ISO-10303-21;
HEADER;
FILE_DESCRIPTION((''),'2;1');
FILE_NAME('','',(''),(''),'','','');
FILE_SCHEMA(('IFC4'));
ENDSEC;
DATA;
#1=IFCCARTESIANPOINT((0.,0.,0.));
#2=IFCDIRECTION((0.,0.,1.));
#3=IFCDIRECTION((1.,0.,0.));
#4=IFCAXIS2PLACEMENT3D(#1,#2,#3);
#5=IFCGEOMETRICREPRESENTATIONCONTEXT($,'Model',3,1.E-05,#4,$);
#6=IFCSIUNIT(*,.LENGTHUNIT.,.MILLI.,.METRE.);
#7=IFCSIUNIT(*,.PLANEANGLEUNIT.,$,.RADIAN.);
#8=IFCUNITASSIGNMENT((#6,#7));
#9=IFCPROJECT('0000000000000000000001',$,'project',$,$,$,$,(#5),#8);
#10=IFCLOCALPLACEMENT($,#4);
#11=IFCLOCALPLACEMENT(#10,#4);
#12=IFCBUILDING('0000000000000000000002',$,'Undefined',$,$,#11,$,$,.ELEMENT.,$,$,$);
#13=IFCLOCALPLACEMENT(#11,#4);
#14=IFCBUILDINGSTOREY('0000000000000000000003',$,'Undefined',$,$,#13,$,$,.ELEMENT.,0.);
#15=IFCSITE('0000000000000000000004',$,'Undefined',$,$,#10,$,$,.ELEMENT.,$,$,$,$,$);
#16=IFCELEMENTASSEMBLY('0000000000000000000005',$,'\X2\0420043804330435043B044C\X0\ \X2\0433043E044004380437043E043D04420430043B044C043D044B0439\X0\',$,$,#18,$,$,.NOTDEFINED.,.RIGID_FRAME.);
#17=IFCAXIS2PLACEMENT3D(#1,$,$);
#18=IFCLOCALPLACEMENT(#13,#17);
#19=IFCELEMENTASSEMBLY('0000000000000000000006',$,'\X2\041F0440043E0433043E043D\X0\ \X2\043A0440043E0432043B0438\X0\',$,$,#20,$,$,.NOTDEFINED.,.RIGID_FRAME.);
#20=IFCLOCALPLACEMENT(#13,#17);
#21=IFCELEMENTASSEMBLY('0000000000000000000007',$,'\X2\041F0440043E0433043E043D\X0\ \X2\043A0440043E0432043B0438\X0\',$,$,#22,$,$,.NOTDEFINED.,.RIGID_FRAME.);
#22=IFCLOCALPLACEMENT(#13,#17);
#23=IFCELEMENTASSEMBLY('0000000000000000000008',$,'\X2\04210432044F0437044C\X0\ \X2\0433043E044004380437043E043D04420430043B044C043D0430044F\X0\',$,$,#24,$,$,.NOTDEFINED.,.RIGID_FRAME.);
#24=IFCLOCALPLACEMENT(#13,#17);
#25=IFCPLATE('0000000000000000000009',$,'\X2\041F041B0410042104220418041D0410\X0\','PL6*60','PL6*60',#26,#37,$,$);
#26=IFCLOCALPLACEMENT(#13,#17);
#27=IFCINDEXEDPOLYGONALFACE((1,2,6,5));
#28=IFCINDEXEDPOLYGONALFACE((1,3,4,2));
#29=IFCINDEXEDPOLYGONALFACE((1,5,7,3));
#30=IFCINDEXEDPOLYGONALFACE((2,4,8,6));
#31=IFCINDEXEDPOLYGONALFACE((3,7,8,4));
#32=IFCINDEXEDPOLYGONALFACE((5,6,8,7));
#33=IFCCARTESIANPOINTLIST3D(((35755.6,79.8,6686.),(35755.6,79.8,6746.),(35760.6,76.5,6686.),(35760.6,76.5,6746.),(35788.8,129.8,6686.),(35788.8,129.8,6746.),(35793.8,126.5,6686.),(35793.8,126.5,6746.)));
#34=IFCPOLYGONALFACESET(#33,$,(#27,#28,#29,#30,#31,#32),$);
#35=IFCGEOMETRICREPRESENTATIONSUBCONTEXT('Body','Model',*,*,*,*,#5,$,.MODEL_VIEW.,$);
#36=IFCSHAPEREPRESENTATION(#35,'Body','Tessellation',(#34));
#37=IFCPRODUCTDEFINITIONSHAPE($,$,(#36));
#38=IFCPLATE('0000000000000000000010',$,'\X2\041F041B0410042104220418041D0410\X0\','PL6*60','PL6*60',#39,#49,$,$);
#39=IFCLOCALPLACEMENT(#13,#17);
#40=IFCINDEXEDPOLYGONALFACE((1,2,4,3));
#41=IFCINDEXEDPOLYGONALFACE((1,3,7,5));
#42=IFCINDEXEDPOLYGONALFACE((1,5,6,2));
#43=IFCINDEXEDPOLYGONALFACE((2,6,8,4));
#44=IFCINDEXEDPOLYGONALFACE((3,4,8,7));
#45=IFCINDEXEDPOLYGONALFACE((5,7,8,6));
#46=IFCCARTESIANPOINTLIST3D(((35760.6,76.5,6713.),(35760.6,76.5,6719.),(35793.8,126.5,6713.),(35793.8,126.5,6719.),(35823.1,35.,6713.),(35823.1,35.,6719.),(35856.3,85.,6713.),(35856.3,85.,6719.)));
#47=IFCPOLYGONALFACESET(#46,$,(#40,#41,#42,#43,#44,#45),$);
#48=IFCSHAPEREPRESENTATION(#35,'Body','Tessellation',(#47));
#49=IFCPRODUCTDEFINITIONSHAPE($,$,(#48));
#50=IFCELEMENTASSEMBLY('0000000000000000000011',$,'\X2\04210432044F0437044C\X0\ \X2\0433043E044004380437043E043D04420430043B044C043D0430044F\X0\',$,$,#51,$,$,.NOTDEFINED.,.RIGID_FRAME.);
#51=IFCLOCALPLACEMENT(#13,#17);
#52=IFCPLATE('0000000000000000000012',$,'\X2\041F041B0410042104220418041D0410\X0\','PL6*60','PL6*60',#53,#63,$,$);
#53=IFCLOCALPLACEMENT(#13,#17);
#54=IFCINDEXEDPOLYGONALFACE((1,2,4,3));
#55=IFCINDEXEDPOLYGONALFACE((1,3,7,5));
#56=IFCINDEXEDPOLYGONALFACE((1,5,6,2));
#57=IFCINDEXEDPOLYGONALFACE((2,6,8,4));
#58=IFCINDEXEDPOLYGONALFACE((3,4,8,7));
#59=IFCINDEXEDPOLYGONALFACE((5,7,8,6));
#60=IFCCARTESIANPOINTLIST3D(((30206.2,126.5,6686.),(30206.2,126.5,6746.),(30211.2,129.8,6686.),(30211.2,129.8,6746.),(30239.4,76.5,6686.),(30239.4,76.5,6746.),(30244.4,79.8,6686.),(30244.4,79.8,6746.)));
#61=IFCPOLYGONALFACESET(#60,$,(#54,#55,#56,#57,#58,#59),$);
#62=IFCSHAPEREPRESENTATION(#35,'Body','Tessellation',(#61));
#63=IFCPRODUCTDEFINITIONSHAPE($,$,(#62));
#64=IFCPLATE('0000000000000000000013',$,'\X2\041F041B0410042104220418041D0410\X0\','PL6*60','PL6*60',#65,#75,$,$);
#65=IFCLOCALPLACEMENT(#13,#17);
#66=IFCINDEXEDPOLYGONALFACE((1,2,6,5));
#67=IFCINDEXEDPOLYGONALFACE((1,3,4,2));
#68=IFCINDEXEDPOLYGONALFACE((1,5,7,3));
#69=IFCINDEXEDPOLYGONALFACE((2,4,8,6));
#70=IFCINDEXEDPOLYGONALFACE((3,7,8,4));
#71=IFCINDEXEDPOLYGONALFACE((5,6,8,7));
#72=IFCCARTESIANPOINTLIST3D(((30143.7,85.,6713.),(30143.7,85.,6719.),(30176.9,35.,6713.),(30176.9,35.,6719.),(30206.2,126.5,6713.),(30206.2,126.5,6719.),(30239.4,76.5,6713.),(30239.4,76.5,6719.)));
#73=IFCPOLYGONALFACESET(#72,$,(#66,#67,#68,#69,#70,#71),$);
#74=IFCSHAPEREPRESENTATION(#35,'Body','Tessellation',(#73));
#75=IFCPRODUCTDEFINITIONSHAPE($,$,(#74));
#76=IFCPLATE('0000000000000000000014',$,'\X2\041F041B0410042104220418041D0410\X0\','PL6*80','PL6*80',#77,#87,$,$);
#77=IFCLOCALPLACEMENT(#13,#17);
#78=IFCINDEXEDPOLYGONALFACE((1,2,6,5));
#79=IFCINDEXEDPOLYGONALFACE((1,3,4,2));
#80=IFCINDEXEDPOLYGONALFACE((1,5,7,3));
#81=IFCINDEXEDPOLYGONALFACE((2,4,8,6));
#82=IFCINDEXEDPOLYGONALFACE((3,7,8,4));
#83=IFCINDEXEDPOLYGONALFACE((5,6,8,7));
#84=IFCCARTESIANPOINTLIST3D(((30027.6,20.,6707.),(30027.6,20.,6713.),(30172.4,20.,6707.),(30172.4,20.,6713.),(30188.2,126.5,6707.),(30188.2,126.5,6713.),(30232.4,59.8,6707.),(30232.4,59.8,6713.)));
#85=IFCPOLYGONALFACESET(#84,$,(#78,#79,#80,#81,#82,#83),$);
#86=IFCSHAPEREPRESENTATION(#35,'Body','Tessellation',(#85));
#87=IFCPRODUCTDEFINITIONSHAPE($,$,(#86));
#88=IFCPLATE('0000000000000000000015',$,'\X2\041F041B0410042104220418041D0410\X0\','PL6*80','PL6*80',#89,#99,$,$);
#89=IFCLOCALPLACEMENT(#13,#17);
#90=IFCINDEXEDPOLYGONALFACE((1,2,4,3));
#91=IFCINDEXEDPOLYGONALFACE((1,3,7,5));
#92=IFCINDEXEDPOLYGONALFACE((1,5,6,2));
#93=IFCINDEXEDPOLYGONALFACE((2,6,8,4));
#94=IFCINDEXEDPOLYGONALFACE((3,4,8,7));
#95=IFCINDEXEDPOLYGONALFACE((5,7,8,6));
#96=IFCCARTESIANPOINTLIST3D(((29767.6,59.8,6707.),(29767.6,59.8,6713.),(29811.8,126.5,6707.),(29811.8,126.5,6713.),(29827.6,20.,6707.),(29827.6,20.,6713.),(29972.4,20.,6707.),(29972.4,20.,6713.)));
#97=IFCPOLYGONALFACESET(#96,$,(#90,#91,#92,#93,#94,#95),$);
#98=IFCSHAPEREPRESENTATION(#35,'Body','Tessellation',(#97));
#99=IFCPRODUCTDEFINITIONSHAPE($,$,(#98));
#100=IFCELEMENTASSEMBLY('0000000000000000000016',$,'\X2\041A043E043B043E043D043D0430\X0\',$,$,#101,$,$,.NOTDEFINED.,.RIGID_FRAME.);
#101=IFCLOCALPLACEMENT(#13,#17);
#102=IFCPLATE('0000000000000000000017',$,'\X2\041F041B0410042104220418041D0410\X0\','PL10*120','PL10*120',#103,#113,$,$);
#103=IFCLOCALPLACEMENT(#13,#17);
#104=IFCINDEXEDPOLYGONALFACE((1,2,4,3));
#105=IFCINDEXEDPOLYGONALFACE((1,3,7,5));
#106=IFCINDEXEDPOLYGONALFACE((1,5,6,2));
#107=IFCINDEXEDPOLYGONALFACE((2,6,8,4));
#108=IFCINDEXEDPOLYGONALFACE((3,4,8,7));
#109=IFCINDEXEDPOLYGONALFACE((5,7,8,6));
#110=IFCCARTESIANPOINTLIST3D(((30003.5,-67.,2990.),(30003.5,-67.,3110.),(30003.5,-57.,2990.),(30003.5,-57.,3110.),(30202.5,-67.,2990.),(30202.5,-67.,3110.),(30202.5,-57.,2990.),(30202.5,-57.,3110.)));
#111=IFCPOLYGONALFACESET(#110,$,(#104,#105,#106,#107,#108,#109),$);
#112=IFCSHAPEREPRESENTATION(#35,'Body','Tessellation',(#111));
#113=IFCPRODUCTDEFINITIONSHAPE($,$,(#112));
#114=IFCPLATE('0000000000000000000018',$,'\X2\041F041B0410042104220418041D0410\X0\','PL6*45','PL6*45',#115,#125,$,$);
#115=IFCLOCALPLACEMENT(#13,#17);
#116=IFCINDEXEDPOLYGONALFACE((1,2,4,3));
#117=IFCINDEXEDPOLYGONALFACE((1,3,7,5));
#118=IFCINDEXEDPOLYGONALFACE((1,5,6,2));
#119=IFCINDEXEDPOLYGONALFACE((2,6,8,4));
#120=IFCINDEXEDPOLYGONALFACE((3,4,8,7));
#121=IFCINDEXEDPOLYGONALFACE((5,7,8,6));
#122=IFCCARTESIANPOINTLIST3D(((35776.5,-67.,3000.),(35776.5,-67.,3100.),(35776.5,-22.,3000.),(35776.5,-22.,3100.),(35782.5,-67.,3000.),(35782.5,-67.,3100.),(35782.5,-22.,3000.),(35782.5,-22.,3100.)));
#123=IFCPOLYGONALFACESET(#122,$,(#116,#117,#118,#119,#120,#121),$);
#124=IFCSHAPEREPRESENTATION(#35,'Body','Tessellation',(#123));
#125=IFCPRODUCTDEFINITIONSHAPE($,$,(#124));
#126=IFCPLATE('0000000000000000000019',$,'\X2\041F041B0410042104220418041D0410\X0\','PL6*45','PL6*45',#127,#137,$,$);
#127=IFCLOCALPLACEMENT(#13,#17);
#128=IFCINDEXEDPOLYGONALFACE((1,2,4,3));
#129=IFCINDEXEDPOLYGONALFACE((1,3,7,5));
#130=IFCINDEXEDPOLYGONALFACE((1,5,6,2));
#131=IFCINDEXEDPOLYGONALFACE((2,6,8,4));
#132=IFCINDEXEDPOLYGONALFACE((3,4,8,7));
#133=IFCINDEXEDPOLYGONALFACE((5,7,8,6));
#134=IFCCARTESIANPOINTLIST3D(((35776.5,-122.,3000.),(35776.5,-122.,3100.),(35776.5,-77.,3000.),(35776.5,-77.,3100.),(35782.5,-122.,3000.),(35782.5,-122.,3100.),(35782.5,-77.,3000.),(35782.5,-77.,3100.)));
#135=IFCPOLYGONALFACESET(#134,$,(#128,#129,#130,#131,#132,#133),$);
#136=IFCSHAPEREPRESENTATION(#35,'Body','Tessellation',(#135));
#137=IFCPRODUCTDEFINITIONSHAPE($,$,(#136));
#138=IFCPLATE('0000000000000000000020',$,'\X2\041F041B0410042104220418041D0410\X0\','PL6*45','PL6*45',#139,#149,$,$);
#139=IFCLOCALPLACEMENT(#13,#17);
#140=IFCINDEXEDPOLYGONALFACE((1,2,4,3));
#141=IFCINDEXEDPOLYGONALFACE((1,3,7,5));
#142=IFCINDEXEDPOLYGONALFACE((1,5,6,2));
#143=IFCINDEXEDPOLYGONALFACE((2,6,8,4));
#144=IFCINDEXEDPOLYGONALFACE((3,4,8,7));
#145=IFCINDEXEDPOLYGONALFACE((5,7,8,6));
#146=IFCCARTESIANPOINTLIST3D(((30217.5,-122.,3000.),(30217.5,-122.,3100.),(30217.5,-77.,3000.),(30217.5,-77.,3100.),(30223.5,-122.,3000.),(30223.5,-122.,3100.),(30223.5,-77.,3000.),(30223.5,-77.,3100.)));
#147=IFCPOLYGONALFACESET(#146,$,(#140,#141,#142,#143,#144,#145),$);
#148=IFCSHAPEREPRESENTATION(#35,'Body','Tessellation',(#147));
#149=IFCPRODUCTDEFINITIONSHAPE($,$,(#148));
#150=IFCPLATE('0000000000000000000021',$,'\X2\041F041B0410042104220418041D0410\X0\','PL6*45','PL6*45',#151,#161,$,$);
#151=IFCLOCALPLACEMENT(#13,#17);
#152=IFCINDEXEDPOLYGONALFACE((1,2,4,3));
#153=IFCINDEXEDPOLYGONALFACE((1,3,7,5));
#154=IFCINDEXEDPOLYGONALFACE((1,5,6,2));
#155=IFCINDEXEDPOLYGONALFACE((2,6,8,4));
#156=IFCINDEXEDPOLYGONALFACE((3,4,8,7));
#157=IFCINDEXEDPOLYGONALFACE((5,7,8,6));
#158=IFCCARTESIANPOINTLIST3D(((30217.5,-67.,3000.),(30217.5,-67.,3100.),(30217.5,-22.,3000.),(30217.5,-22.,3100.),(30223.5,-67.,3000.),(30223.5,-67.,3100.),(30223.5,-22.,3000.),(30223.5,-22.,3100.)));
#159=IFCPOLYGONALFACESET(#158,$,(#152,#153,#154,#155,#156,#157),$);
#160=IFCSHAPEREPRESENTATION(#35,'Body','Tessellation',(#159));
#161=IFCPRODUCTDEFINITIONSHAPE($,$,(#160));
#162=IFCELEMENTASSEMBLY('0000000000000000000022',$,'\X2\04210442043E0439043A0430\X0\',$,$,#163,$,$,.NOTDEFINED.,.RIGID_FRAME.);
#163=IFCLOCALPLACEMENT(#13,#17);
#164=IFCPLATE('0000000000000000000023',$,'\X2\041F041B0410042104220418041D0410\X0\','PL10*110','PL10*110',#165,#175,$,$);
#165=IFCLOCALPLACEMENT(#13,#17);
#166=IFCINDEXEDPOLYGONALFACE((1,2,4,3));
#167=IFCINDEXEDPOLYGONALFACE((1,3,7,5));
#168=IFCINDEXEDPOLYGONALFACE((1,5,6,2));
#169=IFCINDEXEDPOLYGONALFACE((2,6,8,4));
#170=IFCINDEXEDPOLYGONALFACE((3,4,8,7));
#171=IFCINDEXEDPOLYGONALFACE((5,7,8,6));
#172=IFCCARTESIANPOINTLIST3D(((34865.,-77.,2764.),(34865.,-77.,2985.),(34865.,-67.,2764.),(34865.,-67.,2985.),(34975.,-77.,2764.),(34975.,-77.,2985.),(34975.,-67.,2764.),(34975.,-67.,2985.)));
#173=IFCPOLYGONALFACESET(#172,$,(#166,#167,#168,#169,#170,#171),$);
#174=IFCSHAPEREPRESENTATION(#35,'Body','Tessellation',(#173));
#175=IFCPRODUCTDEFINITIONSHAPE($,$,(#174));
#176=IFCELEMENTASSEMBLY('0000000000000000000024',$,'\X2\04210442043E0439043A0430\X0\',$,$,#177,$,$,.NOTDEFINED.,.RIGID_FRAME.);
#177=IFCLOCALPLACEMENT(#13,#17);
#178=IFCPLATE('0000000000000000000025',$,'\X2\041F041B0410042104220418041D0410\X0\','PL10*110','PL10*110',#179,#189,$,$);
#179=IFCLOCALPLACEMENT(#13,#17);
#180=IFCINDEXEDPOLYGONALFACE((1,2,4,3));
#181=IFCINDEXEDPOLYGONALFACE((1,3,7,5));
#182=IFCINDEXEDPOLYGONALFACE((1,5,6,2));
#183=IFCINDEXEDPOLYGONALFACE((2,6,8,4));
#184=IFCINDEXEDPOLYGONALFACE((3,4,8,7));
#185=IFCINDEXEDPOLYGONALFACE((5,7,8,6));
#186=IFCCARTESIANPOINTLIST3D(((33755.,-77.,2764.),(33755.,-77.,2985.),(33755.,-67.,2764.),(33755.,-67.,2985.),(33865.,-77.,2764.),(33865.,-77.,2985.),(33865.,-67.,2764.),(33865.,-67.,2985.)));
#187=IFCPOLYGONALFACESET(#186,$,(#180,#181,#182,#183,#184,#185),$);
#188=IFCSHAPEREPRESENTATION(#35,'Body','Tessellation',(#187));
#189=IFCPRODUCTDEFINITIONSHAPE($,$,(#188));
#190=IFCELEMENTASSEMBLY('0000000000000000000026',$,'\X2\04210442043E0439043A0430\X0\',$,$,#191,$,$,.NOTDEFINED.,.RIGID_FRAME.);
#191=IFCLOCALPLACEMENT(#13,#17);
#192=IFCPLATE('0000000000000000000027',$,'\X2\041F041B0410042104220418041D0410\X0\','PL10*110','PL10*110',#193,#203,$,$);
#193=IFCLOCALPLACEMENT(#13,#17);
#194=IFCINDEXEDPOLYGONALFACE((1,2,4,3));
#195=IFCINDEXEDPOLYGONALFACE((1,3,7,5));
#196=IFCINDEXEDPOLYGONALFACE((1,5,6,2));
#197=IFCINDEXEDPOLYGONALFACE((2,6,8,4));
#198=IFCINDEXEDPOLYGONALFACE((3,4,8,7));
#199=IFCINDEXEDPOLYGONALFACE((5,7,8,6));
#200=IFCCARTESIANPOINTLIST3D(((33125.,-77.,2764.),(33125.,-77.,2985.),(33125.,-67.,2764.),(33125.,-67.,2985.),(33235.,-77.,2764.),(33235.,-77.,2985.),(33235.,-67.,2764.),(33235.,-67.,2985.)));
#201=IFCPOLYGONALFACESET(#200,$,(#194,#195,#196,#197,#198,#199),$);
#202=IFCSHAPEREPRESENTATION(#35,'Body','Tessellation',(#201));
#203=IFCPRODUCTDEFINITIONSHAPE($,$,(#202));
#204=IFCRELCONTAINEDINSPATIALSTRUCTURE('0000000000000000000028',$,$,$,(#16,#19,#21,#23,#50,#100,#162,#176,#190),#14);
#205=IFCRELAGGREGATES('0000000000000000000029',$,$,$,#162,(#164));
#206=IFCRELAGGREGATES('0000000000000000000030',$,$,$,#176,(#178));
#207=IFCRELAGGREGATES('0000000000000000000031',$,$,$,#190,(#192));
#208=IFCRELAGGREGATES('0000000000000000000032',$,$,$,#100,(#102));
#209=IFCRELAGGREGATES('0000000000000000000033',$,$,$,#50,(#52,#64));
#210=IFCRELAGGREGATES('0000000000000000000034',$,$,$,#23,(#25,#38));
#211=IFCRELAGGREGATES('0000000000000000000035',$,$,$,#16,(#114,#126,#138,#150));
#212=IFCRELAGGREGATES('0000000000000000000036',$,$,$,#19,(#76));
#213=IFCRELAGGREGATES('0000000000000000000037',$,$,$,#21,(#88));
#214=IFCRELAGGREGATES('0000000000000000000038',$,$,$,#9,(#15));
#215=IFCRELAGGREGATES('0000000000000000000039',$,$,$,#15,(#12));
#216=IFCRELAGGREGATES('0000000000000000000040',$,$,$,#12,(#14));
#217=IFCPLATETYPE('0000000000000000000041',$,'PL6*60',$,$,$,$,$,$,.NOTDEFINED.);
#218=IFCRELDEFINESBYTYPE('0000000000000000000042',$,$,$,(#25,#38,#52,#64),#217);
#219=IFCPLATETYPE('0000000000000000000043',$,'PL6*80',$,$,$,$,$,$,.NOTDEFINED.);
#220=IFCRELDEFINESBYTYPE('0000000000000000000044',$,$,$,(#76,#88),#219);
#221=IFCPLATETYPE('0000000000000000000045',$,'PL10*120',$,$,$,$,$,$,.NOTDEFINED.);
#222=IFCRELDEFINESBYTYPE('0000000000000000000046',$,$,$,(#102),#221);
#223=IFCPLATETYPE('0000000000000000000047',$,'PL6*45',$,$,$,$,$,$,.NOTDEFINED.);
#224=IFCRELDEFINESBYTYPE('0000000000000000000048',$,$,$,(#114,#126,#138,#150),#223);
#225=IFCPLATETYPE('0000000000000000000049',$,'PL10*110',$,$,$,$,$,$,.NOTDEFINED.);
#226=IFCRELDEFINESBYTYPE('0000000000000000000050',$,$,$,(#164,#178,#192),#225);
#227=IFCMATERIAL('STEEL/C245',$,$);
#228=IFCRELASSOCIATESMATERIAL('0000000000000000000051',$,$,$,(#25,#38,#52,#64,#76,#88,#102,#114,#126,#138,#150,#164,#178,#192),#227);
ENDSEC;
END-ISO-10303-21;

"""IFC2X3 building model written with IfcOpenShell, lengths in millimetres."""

from ifc_helpers import new_model, si_unit, frame, origin_with_axes, place, context, subcontext, project, spatial, polyline, outline, extrude, material, type_object, element, aggregate, save


model = new_model("IFC2X3")

# Units and contexts
model_context = context("Model", 3, precision=1e-05, world=origin_with_axes())
body_context = subcontext(model_context, "Body", "Model", "MODEL_VIEW")
ifc_project = project(units=[si_unit("LENGTHUNIT", "METRE", prefix="MILLI"), si_unit("PLANEANGLEUNIT", "RADIAN")], contexts=[model_context])

# Site, building, storey
site_placement = place(None, origin_with_axes())
site = spatial("IfcSite", under=ifc_project, at=site_placement, Name="Undefined", CompositionType="ELEMENT")
building_placement = place(site_placement, origin_with_axes())
building = spatial("IfcBuilding", under=site, at=building_placement, Name="Undefined", CompositionType="ELEMENT")
storey_placement = place(building_placement, origin_with_axes())
storey = spatial("IfcBuildingStorey", under=building, at=storey_placement, Name="Undefined", CompositionType="ELEMENT", Elevation=0.0)

# Element assemblies
assembly_1_placement = place(storey_placement, origin_with_axes())
assembly_1 = element("IfcElementAssembly", 1, at=assembly_1_placement, inside=storey, Name="Ригель горизонтальный", AssemblyPlace="NOTDEFINED", PredefinedType="RIGID_FRAME")
ifc_material_1 = material(Name="STEEL/C245")
assembly_2_placement = place(storey_placement, origin_with_axes())
assembly_2 = element("IfcElementAssembly", 2, at=assembly_2_placement, inside=storey, Name="Прогон кровли", AssemblyPlace="NOTDEFINED", PredefinedType="RIGID_FRAME")
assembly_3_placement = place(storey_placement, origin_with_axes())
assembly_3 = element("IfcElementAssembly", 3, at=assembly_3_placement, inside=storey, Name="Прогон кровли", AssemblyPlace="NOTDEFINED", PredefinedType="RIGID_FRAME")

# Element assemblies, plates
assembly_4_placement = place(storey_placement, origin_with_axes())
assembly_4 = element("IfcElementAssembly", 4, at=assembly_4_placement, inside=storey, Name="Связь горизонтальная", AssemblyPlace="NOTDEFINED", PredefinedType="RIGID_FRAME")
plate_type_1 = type_object("IfcPlateType", Name="PL6*60", PredefinedType="NOTDEFINED")
plate_1_placement = place(assembly_4_placement, frame((35774.7, 103.1, 6746.0), z_axis=(0.833383, -0.552695, 0.0), x_axis=(0.0, 0.0, -1.0)))
plate_1 = element("IfcPlate", 5, at=plate_1_placement, type_object=plate_type_1, material=ifc_material_1, Name="ПЛАСТИНА", Description="PL6*60", ObjectType="PL6*60", context=body_context, shape_type="SweptSolid", body=[
    extrude(outline(polyline([(60.0, -30.0), (0.0, -30.0), (0.0, 30.0), (60.0, 30.0), (60.0, -30.0)])), frame((0.0, 0.0, -3.0), z_axis=(0.0, 0.0, 1.0), x_axis=(1.0, 0.0, 0.0)), (0.0, 0.0, 1.0), 6.0),
])
plate_2_placement = place(assembly_4_placement, frame((35839.7, 60.0, 6716.0), z_axis=(0.0, 0.0, 1.0), x_axis=(-0.833383, 0.552695, 0.0)))
plate_2 = element("IfcPlate", 6, at=plate_2_placement, type_object=plate_type_1, material=ifc_material_1, Name="ПЛАСТИНА", Description="PL6*60", ObjectType="PL6*60", context=body_context, shape_type="SweptSolid", body=[
    extrude(outline(polyline([(75.0, 30.0), (75.0, -30.0), (0.0, -30.0), (0.0, 30.0), (75.0, 30.0)])), frame((0.0, 0.0, -3.0), z_axis=(0.0, 0.0, 1.0), x_axis=(1.0, 0.0, 0.0)), (0.0, 0.0, 1.0), 6.0),
])
assembly_5_placement = place(storey_placement, origin_with_axes())
assembly_5 = element("IfcElementAssembly", 7, at=assembly_5_placement, inside=storey, Name="Связь горизонтальная", AssemblyPlace="NOTDEFINED", PredefinedType="RIGID_FRAME")
plate_3_placement = place(assembly_5_placement, frame((30225.3, 103.1, 6686.0), z_axis=(-0.833383, -0.552695, 0.0), x_axis=(0.0, 0.0, 1.0)))
plate_3 = element("IfcPlate", 8, at=plate_3_placement, type_object=plate_type_1, material=ifc_material_1, Name="ПЛАСТИНА", Description="PL6*60", ObjectType="PL6*60", context=body_context, shape_type="SweptSolid", body=[
    extrude(outline(polyline([(0.0, 30.0), (60.0, 30.0), (60.0, -30.0), (0.0, -30.0), (0.0, 30.0)])), frame((0.0, 0.0, -3.0), z_axis=(0.0, 0.0, 1.0), x_axis=(1.0, 0.0, 0.0)), (0.0, 0.0, 1.0), 6.0),
])
plate_4_placement = place(assembly_5_placement, frame((30160.3, 60.0, 6716.0), z_axis=(0.0, 0.0, -1.0), x_axis=(0.833383, 0.552695, 0.0)))
plate_4 = element("IfcPlate", 9, at=plate_4_placement, type_object=plate_type_1, material=ifc_material_1, Name="ПЛАСТИНА", Description="PL6*60", ObjectType="PL6*60", context=body_context, shape_type="SweptSolid", body=[
    extrude(outline(polyline([(0.0, -30.0), (0.0, 30.0), (75.0, 30.0), (75.0, -30.0), (0.0, -30.0)])), frame((0.0, 0.0, -3.0), z_axis=(0.0, 0.0, 1.0), x_axis=(1.0, 0.0, 0.0)), (0.0, 0.0, 1.0), 6.0),
])

# Plates
plate_type_2 = type_object("IfcPlateType", Name="PL6*80", PredefinedType="NOTDEFINED")
plate_5_placement = place(assembly_2_placement, frame((30027.6, 20.0, 6710.0), z_axis=(0.0, 0.0, -1.0), x_axis=(0.833383, 0.552695, 0.0)))
plate_5 = element("IfcPlate", 10, at=plate_5_placement, type_object=plate_type_2, material=ifc_material_1, Name="ПЛАСТИНА", Description="PL6*80", ObjectType="PL6*80", context=body_context, shape_type="SweptSolid", body=[
    extrude(outline(polyline([(0.0, 0.0), (192.7, 0.0), (192.7, 80.0), (120.6, 80.0), (0.0, 0.0)])), frame((0.0, 0.0, -3.0), z_axis=(0.0, 0.0, 1.0), x_axis=(1.0, 0.0, 0.0)), (0.0, 0.0, 1.0), 6.0),
])
plate_6_placement = place(assembly_3_placement, frame((29972.4, 20.0, 6710.0), z_axis=(0.0, 0.0, 1.0), x_axis=(-0.833383, 0.552695, 0.0)))
plate_6 = element("IfcPlate", 11, at=plate_6_placement, type_object=plate_type_2, material=ifc_material_1, Name="ПЛАСТИНА", Description="PL6*80", ObjectType="PL6*80", context=body_context, shape_type="SweptSolid", body=[
    extrude(outline(polyline([(0.0, 0.0), (192.7, 0.0), (192.7, 80.0), (120.6, 80.0), (0.0, 0.0)])), frame((0.0, 0.0, -3.0), z_axis=(0.0, 0.0, 1.0), x_axis=(1.0, 0.0, 0.0)), (0.0, 0.0, 1.0), 6.0),
])

# Element assembly, plate
assembly_6_placement = place(storey_placement, origin_with_axes())
assembly_6 = element("IfcElementAssembly", 12, at=assembly_6_placement, inside=storey, Name="Колонна", AssemblyPlace="NOTDEFINED", PredefinedType="RIGID_FRAME")
plate_type_3 = type_object("IfcPlateType", Name="PL10*120", PredefinedType="NOTDEFINED")
plate_7_placement = place(assembly_6_placement, frame((30003.5, -62.0, 2990.0), z_axis=(0.0, -1.0, 0.0), x_axis=(1.0, 0.0, 0.0)))
plate_7 = element("IfcPlate", 13, at=plate_7_placement, type_object=plate_type_3, material=ifc_material_1, Name="ПЛАСТИНА", Description="PL10*120", ObjectType="PL10*120", context=body_context, shape_type="SweptSolid", body=[
    extrude(outline(polyline([(0.0, 0.0), (199.0, 0.0), (199.0, 120.0), (0.0, 120.0), (0.0, 0.0)])), frame((0.0, 0.0, -5.0), z_axis=(0.0, 0.0, 1.0), x_axis=(1.0, 0.0, 0.0)), (0.0, 0.0, 1.0), 10.0),
])

# Plates
plate_type_4 = type_object("IfcPlateType", Name="PL6*45", PredefinedType="NOTDEFINED")
plate_8_placement = place(assembly_1_placement, frame((35779.5, -44.5, 3100.0), z_axis=(-1.0, 0.0, 0.0), x_axis=(0.0, 0.0, -1.0)))
plate_8 = element("IfcPlate", 14, at=plate_8_placement, type_object=plate_type_4, material=ifc_material_1, Name="ПЛАСТИНА", Description="PL6*45", ObjectType="PL6*45", context=body_context, shape_type="SweptSolid", body=[
    extrude(outline(polyline([(100.0, 22.5), (100.0, -22.5), (0.0, -22.5), (0.0, 22.5), (100.0, 22.5)])), frame((0.0, 0.0, -3.0), z_axis=(0.0, 0.0, 1.0), x_axis=(1.0, 0.0, 0.0)), (0.0, 0.0, 1.0), 6.0),
])
plate_9_placement = place(assembly_1_placement, frame((35779.5, -99.5, 3100.0), z_axis=(1.0, 0.0, 0.0), x_axis=(0.0, 0.0, -1.0)))
plate_9 = element("IfcPlate", 15, at=plate_9_placement, type_object=plate_type_4, material=ifc_material_1, Name="ПЛАСТИНА", Description="PL6*45", ObjectType="PL6*45", context=body_context, shape_type="SweptSolid", body=[
    extrude(outline(polyline([(100.0, -22.5), (0.0, -22.5), (0.0, 22.5), (100.0, 22.5), (100.0, -22.5)])), frame((0.0, 0.0, -3.0), z_axis=(0.0, 0.0, 1.0), x_axis=(1.0, 0.0, 0.0)), (0.0, 0.0, 1.0), 6.0),
])
plate_10_placement = place(assembly_1_placement, frame((30220.5, -99.5, 3100.0), z_axis=(1.0, 0.0, 0.0), x_axis=(0.0, 0.0, -1.0)))
plate_10 = element("IfcPlate", 16, at=plate_10_placement, type_object=plate_type_4, material=ifc_material_1, Name="ПЛАСТИНА", Description="PL6*45", ObjectType="PL6*45", context=body_context, shape_type="SweptSolid", body=[
    extrude(outline(polyline([(100.0, -22.5), (0.0, -22.5), (0.0, 22.5), (100.0, 22.5), (100.0, -22.5)])), frame((0.0, 0.0, -3.0), z_axis=(0.0, 0.0, 1.0), x_axis=(1.0, 0.0, 0.0)), (0.0, 0.0, 1.0), 6.0),
])
plate_11_placement = place(assembly_1_placement, frame((30220.5, -44.5, 3100.0), z_axis=(-1.0, 0.0, 0.0), x_axis=(0.0, 0.0, -1.0)))
plate_11 = element("IfcPlate", 17, at=plate_11_placement, type_object=plate_type_4, material=ifc_material_1, Name="ПЛАСТИНА", Description="PL6*45", ObjectType="PL6*45", context=body_context, shape_type="SweptSolid", body=[
    extrude(outline(polyline([(100.0, 22.5), (100.0, -22.5), (0.0, -22.5), (0.0, 22.5), (100.0, 22.5)])), frame((0.0, 0.0, -3.0), z_axis=(0.0, 0.0, 1.0), x_axis=(1.0, 0.0, 0.0)), (0.0, 0.0, 1.0), 6.0),
])

# Element assemblies, plates
assembly_7_placement = place(storey_placement, origin_with_axes())
assembly_7 = element("IfcElementAssembly", 18, at=assembly_7_placement, inside=storey, Name="Стойка", AssemblyPlace="NOTDEFINED", PredefinedType="RIGID_FRAME")
plate_type_5 = type_object("IfcPlateType", Name="PL10*110", PredefinedType="NOTDEFINED")
plate_12_placement = place(assembly_7_placement, frame((34920.0, -72.0, 2985.0), z_axis=(0.0, -1.0, 0.0), x_axis=(0.0, 0.0, -1.0)))
plate_12 = element("IfcPlate", 19, at=plate_12_placement, type_object=plate_type_5, material=ifc_material_1, Name="ПЛАСТИНА", Description="PL10*110", ObjectType="PL10*110", context=body_context, shape_type="SweptSolid", body=[
    extrude(outline(polyline([(221.0, -55.0), (0.0, -55.0), (0.0, 55.0), (221.0, 55.0), (221.0, -55.0)])), frame((0.0, 0.0, -5.0), z_axis=(0.0, 0.0, 1.0), x_axis=(1.0, 0.0, 0.0)), (0.0, 0.0, 1.0), 10.0),
])
aggregate(assembly_7, [plate_12])
assembly_8_placement = place(storey_placement, origin_with_axes())
assembly_8 = element("IfcElementAssembly", 20, at=assembly_8_placement, inside=storey, Name="Стойка", AssemblyPlace="NOTDEFINED", PredefinedType="RIGID_FRAME")
plate_13_placement = place(assembly_8_placement, frame((33810.0, -72.0, 2985.0), z_axis=(0.0, -1.0, 0.0), x_axis=(0.0, 0.0, -1.0)))
plate_13 = element("IfcPlate", 21, at=plate_13_placement, type_object=plate_type_5, material=ifc_material_1, Name="ПЛАСТИНА", Description="PL10*110", ObjectType="PL10*110", context=body_context, shape_type="SweptSolid", body=[
    extrude(outline(polyline([(221.0, -55.0), (0.0, -55.0), (0.0, 55.0), (221.0, 55.0), (221.0, -55.0)])), frame((0.0, 0.0, -5.0), z_axis=(0.0, 0.0, 1.0), x_axis=(1.0, 0.0, 0.0)), (0.0, 0.0, 1.0), 10.0),
])
aggregate(assembly_8, [plate_13])
assembly_9_placement = place(storey_placement, origin_with_axes())
assembly_9 = element("IfcElementAssembly", 22, at=assembly_9_placement, inside=storey, Name="Стойка", AssemblyPlace="NOTDEFINED", PredefinedType="RIGID_FRAME")
plate_14_placement = place(assembly_9_placement, frame((33180.0, -72.0, 2985.0), z_axis=(0.0, -1.0, 0.0), x_axis=(0.0, 0.0, -1.0)))
plate_14 = element("IfcPlate", 23, at=plate_14_placement, type_object=plate_type_5, material=ifc_material_1, Name="ПЛАСТИНА", Description="PL10*110", ObjectType="PL10*110", context=body_context, shape_type="SweptSolid", body=[
    extrude(outline(polyline([(221.0, -55.0), (0.0, -55.0), (0.0, 55.0), (221.0, 55.0), (221.0, -55.0)])), frame((0.0, 0.0, -5.0), z_axis=(0.0, 0.0, 1.0), x_axis=(1.0, 0.0, 0.0)), (0.0, 0.0, 1.0), 10.0),
])
aggregate(assembly_9, [plate_14])

aggregate(assembly_6, [plate_7])

aggregate(assembly_5, [plate_3, plate_4])
aggregate(assembly_4, [plate_1, plate_2])
aggregate(assembly_1, [plate_8, plate_9, plate_10, plate_11])
aggregate(assembly_2, [plate_5])
aggregate(assembly_3, [plate_6])

save(model, "model.ifc")
